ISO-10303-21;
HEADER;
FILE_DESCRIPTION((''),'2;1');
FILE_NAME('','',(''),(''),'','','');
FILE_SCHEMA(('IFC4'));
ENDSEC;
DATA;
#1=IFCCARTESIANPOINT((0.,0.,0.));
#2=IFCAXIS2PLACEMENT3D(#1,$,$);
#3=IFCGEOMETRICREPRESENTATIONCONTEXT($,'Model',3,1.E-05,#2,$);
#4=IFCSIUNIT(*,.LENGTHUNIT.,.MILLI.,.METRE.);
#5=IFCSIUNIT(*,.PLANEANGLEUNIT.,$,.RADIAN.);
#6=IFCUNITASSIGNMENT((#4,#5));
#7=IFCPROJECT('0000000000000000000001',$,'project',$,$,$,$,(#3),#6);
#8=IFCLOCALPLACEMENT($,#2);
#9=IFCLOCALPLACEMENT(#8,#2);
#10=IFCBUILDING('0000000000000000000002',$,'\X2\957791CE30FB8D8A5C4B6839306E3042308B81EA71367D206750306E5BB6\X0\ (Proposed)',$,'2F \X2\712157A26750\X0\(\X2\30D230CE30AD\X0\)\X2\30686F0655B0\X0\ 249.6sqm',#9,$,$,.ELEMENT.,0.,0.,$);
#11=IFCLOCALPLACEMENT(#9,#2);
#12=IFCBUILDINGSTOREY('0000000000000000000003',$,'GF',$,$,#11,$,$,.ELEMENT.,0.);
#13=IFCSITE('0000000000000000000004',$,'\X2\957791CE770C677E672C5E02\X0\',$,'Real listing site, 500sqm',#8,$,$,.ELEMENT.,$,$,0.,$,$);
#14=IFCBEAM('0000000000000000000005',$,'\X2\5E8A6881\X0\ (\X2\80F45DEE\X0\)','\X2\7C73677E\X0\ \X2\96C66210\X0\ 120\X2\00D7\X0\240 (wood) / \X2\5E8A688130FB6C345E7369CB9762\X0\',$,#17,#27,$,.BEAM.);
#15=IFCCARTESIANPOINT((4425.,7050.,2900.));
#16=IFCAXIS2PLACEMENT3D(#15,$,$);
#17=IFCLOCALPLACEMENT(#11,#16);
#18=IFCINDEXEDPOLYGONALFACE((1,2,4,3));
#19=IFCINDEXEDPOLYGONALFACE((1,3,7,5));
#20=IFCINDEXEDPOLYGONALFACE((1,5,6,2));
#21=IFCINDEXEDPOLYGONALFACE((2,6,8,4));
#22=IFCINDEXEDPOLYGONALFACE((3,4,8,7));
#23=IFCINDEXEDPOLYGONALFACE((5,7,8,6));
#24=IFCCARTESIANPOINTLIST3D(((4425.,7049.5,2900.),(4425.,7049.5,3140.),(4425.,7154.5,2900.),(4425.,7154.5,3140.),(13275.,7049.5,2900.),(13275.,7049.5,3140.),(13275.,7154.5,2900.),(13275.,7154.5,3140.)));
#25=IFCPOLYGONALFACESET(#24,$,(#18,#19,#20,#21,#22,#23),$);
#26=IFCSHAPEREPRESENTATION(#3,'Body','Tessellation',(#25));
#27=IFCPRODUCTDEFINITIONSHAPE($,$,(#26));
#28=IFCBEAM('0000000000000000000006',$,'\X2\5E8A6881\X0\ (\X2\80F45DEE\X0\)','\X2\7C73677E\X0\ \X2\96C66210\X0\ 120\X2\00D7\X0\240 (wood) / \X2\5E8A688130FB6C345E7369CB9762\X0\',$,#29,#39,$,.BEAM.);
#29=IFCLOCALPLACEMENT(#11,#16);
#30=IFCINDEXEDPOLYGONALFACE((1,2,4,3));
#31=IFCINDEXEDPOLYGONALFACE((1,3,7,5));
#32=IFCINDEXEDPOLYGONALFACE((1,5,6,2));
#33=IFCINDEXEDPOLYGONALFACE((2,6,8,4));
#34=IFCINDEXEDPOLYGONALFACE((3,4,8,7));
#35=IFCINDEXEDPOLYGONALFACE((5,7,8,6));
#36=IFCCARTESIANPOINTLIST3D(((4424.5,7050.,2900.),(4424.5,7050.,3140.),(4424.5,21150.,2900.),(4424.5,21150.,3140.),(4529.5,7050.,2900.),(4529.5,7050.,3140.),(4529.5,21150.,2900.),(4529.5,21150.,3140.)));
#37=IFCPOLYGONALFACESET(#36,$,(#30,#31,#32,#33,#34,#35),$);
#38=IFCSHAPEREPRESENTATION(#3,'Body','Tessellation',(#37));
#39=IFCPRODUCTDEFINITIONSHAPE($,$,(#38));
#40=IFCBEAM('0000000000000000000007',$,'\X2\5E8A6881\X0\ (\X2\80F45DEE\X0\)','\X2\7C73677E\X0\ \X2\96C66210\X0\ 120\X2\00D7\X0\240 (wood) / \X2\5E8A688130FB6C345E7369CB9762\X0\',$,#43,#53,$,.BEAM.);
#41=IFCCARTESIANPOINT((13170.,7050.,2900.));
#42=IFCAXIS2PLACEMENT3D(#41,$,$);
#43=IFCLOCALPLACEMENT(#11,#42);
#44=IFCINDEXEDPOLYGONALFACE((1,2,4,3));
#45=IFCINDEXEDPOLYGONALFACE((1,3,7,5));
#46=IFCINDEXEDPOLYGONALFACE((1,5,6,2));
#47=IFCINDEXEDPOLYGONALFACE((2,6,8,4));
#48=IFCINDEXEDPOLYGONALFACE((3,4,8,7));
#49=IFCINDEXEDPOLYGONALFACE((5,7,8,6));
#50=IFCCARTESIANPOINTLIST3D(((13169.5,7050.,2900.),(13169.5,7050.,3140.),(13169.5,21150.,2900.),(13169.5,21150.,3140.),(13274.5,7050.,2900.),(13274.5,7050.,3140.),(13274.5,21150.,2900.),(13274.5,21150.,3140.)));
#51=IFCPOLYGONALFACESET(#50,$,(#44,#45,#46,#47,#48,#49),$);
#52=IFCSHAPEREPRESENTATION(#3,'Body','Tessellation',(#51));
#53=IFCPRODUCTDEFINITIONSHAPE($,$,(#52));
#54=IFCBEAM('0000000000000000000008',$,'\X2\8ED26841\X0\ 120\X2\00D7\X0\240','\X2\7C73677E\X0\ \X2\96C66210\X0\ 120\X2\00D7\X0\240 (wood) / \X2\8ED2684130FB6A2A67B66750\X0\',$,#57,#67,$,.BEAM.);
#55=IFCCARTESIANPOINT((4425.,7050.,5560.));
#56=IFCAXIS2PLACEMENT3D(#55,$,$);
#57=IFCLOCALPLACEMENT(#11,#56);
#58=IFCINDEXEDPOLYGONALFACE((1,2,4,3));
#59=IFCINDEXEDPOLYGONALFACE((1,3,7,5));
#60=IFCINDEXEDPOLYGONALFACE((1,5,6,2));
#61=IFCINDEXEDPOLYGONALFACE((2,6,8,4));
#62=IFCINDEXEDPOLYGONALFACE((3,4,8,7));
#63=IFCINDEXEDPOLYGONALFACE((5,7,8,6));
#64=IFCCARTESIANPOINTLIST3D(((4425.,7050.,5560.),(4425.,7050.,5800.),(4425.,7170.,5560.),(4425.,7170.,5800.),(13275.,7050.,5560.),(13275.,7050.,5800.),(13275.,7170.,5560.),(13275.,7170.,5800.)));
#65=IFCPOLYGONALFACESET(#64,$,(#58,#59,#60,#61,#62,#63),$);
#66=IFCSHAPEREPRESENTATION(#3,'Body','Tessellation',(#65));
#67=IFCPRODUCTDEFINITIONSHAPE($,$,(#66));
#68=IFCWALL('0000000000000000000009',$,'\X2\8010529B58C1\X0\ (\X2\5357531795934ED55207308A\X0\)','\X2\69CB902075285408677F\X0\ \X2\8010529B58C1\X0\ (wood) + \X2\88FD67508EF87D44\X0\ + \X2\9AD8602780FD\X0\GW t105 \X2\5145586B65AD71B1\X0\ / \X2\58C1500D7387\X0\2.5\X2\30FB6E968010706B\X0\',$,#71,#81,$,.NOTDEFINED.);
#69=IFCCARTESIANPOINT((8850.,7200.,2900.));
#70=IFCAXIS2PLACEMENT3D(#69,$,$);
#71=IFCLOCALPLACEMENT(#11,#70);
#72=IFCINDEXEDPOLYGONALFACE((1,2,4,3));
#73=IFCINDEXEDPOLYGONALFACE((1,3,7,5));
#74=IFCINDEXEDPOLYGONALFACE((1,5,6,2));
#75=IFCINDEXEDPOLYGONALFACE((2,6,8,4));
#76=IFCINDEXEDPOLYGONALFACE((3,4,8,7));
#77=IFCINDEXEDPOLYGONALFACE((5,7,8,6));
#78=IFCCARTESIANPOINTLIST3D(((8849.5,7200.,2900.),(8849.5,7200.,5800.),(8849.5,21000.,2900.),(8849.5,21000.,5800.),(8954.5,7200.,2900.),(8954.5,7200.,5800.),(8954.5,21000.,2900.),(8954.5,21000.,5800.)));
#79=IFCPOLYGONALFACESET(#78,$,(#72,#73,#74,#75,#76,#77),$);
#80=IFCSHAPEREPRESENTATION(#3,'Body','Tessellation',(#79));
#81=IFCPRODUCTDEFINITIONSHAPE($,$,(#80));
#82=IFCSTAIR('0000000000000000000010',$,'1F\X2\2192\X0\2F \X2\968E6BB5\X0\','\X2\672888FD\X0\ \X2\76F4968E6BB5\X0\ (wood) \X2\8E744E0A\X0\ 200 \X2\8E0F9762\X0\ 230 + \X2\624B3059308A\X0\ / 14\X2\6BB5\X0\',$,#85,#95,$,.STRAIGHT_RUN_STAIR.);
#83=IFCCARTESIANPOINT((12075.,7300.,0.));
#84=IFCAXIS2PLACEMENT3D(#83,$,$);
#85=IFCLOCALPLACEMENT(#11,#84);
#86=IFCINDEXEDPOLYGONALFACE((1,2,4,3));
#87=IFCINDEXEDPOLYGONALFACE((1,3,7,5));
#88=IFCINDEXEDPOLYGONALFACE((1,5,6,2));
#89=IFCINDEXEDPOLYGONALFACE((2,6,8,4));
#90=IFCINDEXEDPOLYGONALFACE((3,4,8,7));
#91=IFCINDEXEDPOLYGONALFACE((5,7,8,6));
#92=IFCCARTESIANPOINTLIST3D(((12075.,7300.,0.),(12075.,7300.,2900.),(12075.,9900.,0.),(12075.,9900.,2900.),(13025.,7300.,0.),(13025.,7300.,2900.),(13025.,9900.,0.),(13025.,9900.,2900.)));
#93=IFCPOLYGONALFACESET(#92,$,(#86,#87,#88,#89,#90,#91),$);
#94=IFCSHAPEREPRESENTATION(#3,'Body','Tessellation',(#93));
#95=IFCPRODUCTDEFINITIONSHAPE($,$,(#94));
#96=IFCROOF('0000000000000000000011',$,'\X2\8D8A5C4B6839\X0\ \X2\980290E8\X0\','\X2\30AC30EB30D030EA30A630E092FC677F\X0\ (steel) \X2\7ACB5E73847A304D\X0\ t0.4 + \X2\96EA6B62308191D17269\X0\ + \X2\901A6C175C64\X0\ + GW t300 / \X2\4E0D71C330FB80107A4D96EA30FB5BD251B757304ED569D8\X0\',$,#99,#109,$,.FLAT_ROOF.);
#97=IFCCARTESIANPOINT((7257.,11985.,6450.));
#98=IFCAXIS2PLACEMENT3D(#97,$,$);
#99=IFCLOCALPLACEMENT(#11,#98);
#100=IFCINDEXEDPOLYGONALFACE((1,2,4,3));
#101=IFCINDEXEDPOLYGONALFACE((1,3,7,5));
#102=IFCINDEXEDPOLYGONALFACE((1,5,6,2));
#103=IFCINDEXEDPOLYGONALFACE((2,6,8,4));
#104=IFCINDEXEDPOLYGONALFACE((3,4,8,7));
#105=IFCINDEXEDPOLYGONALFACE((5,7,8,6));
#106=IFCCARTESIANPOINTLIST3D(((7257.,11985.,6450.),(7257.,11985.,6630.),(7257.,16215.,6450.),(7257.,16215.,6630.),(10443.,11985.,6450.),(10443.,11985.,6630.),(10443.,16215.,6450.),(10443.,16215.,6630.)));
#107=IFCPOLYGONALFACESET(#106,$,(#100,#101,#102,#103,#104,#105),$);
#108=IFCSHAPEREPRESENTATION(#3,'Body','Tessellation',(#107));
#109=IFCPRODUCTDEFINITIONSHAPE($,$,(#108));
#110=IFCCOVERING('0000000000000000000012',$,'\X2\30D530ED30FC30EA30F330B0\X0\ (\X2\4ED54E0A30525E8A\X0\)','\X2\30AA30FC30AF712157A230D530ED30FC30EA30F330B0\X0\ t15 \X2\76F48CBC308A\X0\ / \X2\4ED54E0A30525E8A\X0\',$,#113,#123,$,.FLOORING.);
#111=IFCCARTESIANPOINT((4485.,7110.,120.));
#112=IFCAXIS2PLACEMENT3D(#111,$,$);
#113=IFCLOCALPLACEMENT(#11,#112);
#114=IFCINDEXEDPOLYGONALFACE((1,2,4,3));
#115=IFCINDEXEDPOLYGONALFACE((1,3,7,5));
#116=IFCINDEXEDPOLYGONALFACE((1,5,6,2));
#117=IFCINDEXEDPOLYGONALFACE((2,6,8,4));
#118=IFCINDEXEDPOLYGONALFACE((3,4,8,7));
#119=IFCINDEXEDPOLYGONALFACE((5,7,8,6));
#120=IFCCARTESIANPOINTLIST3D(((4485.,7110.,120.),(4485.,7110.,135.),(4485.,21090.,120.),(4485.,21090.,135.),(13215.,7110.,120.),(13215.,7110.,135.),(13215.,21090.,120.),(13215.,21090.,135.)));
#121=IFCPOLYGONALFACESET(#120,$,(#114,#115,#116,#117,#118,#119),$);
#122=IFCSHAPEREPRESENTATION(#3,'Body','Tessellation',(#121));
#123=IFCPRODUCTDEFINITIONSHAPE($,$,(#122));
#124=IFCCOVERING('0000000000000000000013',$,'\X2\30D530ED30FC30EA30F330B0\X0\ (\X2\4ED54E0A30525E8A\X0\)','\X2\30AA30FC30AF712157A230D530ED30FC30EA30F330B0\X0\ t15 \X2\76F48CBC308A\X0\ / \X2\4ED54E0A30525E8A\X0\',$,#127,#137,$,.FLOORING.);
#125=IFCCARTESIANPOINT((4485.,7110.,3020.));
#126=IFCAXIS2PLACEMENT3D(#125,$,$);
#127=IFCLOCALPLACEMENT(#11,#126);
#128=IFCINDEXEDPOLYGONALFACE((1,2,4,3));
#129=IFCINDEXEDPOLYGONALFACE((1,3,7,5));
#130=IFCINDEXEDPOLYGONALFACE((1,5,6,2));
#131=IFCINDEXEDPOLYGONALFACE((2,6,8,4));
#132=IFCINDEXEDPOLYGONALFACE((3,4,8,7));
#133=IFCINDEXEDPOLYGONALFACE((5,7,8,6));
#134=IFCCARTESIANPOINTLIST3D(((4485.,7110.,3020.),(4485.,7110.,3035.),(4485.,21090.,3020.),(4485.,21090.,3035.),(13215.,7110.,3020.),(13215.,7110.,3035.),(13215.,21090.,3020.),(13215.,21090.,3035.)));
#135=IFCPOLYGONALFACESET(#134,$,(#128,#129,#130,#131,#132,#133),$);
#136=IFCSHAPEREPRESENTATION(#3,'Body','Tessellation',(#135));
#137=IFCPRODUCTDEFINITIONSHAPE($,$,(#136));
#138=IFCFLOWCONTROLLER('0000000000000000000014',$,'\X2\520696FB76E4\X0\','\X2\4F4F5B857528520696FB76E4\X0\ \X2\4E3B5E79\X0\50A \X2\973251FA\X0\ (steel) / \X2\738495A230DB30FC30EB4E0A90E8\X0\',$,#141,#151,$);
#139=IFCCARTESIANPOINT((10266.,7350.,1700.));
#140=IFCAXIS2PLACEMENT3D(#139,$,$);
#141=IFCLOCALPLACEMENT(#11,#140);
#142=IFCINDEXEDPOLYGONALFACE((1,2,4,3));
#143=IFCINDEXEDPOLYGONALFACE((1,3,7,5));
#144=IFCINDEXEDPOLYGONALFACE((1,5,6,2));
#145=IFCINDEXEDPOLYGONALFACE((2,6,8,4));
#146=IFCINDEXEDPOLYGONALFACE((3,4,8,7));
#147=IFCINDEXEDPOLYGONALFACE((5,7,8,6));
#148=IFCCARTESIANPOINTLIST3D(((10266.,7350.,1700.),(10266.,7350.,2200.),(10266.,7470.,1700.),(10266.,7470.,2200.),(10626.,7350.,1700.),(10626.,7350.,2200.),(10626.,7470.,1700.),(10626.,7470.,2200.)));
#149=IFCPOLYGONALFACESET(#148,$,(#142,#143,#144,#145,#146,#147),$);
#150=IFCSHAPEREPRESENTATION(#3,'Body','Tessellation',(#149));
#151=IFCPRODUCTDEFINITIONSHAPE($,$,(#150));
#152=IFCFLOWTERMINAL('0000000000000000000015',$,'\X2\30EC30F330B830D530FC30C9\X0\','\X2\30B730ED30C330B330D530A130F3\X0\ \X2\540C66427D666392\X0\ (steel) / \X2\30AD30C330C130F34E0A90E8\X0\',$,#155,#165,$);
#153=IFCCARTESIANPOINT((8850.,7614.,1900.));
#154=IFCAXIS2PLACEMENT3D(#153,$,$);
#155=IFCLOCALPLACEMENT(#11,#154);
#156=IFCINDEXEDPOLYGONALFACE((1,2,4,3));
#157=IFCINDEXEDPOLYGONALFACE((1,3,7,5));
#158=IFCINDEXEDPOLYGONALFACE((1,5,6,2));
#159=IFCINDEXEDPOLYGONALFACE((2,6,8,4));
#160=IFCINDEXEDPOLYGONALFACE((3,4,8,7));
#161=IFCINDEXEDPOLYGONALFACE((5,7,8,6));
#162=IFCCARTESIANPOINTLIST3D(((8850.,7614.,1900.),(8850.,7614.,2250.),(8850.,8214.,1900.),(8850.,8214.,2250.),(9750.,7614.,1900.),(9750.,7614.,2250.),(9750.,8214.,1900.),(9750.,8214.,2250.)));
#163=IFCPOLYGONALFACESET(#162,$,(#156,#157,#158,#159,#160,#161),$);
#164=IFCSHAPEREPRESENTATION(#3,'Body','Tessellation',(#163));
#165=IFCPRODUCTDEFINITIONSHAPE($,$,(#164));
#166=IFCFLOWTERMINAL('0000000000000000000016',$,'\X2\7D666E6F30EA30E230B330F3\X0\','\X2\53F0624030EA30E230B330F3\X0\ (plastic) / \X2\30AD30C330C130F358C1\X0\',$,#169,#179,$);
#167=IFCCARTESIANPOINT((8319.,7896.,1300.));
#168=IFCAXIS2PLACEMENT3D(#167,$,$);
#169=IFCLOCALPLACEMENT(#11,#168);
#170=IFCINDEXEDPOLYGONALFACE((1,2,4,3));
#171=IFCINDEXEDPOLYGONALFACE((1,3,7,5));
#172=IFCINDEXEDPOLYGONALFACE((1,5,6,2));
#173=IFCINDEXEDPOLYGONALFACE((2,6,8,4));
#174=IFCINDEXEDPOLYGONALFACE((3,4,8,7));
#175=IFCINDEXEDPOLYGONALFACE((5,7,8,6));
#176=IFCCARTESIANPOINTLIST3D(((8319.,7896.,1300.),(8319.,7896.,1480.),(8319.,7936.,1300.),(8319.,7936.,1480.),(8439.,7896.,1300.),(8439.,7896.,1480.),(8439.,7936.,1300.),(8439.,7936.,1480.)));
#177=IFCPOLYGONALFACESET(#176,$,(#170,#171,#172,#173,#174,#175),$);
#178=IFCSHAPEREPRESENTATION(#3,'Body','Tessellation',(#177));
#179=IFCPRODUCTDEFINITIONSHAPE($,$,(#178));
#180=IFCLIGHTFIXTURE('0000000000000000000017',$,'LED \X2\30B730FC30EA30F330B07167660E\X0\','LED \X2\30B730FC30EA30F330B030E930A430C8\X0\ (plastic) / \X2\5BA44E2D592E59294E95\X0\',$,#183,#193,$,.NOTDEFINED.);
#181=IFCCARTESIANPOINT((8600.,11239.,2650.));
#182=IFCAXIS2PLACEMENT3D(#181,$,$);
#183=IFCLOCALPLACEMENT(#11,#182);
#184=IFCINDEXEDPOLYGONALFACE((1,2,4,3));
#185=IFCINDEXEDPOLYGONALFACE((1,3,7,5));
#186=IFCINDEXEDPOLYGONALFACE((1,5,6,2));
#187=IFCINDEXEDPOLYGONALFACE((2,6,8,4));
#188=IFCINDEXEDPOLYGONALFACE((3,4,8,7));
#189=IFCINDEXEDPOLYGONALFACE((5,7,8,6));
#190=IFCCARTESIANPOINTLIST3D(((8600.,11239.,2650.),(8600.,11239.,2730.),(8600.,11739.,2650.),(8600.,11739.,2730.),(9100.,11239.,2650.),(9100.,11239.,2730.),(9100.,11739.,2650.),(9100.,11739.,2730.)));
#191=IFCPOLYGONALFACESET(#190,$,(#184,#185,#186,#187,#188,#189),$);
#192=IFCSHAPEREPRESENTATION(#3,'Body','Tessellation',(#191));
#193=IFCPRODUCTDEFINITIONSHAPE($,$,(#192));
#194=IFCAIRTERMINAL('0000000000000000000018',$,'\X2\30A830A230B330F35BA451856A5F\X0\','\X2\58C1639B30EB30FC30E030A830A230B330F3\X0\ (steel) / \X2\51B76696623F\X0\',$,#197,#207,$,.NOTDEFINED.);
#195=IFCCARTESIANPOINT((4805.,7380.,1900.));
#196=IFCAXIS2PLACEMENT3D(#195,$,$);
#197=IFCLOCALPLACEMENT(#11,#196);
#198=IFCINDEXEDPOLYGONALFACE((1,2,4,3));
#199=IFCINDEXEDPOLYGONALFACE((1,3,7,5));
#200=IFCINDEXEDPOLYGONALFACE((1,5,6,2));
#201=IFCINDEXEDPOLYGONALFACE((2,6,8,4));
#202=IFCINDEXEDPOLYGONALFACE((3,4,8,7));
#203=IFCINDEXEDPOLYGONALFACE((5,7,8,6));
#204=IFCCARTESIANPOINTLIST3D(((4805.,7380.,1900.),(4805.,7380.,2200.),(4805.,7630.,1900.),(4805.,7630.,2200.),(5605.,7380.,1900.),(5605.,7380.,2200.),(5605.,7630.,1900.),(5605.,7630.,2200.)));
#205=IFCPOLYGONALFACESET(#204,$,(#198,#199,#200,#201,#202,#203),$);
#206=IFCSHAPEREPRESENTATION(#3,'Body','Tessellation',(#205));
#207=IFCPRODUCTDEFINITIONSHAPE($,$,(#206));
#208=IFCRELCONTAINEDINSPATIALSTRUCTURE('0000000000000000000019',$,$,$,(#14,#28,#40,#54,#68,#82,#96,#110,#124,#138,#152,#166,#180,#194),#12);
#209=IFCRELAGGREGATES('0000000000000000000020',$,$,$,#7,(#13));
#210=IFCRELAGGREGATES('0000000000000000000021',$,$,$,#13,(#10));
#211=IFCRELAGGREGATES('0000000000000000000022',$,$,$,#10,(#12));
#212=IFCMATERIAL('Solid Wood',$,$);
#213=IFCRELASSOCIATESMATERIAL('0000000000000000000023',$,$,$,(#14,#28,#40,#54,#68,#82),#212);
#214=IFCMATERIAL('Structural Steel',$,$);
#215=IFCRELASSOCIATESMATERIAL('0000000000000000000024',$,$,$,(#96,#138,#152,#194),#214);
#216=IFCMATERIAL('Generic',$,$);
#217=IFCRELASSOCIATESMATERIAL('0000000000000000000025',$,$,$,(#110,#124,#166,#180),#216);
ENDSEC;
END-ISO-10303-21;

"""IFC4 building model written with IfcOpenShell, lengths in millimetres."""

from ifc_helpers import new_model, si_unit, frame, frame_2d, origin, place, context, project, spatial, rectangle, extrude, material, element, save


model = new_model("IFC4")

# Units and contexts
model_context = context("Model", 3, precision=1e-05, world=origin())
ifc_project = project(units=[si_unit("LENGTHUNIT", "METRE", prefix="MILLI"), si_unit("PLANEANGLEUNIT", "RADIAN")], contexts=[model_context])

# Site, building, storey
site_placement = place(None, origin())
site = spatial("IfcSite", under=ifc_project, at=site_placement, Name="長野県松本市", ObjectType="Real listing site, 500sqm", CompositionType="ELEMENT", RefElevation=0.0)
building_placement = place(site_placement, origin())
building = spatial("IfcBuilding", under=site, at=building_placement, Name="長野・越屋根のある自然素材の家 (Proposed)", ObjectType="2F 無垢材(ヒノキ)と漆喰 249.6sqm", CompositionType="ELEMENT", ElevationOfRefHeight=0.0, ElevationOfTerrain=0.0)
storey_placement = place(building_placement, origin())
storey = spatial("IfcBuildingStorey", under=building, at=storey_placement, Name="GF", CompositionType="ELEMENT", Elevation=0.0)

# Shared definitions
ifc_material_1 = material(Name="Solid Wood")

# Beams
beam_1_placement = place(storey_placement, frame((4425.0, 7050.0, 2900.0)))
element("IfcBeam", 1, at=beam_1_placement, inside=storey, material=ifc_material_1, Name="床梁 (胴差)", Description="米松 集成 120×240 (wood) / 床梁・水平構面", PredefinedType="BEAM", context=model_context, shape_type="SweptSolid", body=[
    extrude(rectangle(XDim=8850.0, YDim=105.0, at=frame_2d((4425.0, 52.0))), frame((4425.0, 7050.0, 2900.0)), (0.0, 0.0, 1.0), 240.0),
])
beam_2_placement = place(storey_placement, frame((4425.0, 7050.0, 2900.0)))
element("IfcBeam", 2, at=beam_2_placement, inside=storey, material=ifc_material_1, Name="床梁 (胴差)", Description="米松 集成 120×240 (wood) / 床梁・水平構面", PredefinedType="BEAM", context=model_context, shape_type="SweptSolid", body=[
    extrude(rectangle(XDim=105.0, YDim=14100.0, at=frame_2d((52.0, 7050.0))), frame((4425.0, 7050.0, 2900.0)), (0.0, 0.0, 1.0), 240.0),
])
beam_3_placement = place(storey_placement, frame((13170.0, 7050.0, 2900.0)))
element("IfcBeam", 3, at=beam_3_placement, inside=storey, material=ifc_material_1, Name="床梁 (胴差)", Description="米松 集成 120×240 (wood) / 床梁・水平構面", PredefinedType="BEAM", context=model_context, shape_type="SweptSolid", body=[
    extrude(rectangle(XDim=105.0, YDim=14100.0, at=frame_2d((52.0, 7050.0))), frame((13170.0, 7050.0, 2900.0)), (0.0, 0.0, 1.0), 240.0),
])
beam_4_placement = place(storey_placement, frame((4425.0, 7050.0, 5560.0)))
element("IfcBeam", 4, at=beam_4_placement, inside=storey, material=ifc_material_1, Name="軒桁 120×240", Description="米松 集成 120×240 (wood) / 軒桁・横架材", PredefinedType="BEAM", context=model_context, shape_type="SweptSolid", body=[
    extrude(rectangle(XDim=8850.0, YDim=120.0, at=frame_2d((4425.0, 60.0))), frame((4425.0, 7050.0, 5560.0)), (0.0, 0.0, 1.0), 240.0),
])

# Wall
wall_1_placement = place(storey_placement, frame((8850.0, 7200.0, 2900.0)))
element("IfcWall", 5, at=wall_1_placement, inside=storey, material=ifc_material_1, Name="耐力壁 (南北間仕切り)", Description="構造用合板 耐力壁 (wood) + 製材軸組 + 高性能GW t105 充填断熱 / 壁倍率2.5・準耐火", PredefinedType="NOTDEFINED", context=model_context, shape_type="SweptSolid", body=[
    extrude(rectangle(XDim=105.0, YDim=13800.0, at=frame_2d((52.0, 6900.0))), frame((8850.0, 7200.0, 2900.0)), (0.0, 0.0, 1.0), 2900.0),
])

# Stair
stair_placement = place(storey_placement, frame((12075.0, 7300.0, 0.0)))
element("IfcStair", 6, at=stair_placement, inside=storey, material=ifc_material_1, Name="1F→2F 階段", Description="木製 直階段 (wood) 蹴上 200 踏面 230 + 手すり / 14段", PredefinedType="STRAIGHT_RUN_STAIR", context=model_context, shape_type="SweptSolid", body=[
    extrude(rectangle(XDim=950.0, YDim=2600.0, at=frame_2d((475.0, 1300.0))), frame((12075.0, 7300.0, 0.0)), (0.0, 0.0, 1.0), 2900.0),
])

# Roof
ifc_material_2 = material(Name="Structural Steel")
roof_placement = place(storey_placement, frame((7257.0, 11985.0, 6450.0)))
element("IfcRoof", 7, at=roof_placement, inside=storey, material=ifc_material_2, Name="越屋根 頂部", Description="ガルバリウム鋼板 (steel) 立平葺き t0.4 + 雪止め金物 + 通気層 + GW t300 / 不燃・耐積雪・寒冷地仕様", PredefinedType="FLAT_ROOF", context=model_context, shape_type="SweptSolid", body=[
    extrude(rectangle(XDim=3186.0, YDim=4230.0, at=frame_2d((1593.0, 2115.0))), frame((7257.0, 11985.0, 6450.0)), (0.0, 0.0, 1.0), 180.0),
])

# Coverings
ifc_material_3 = material(Name="Generic")
covering_1_placement = place(storey_placement, frame((4485.0, 7110.0, 120.0)))
element("IfcCovering", 8, at=covering_1_placement, inside=storey, material=ifc_material_3, Name="フローリング (仕上げ床)", Description="オーク無垢フローリング t15 直貼り / 仕上げ床", PredefinedType="FLOORING", context=model_context, shape_type="SweptSolid", body=[
    extrude(rectangle(XDim=8730.0, YDim=13980.0, at=frame_2d((4365.0, 6990.0))), frame((4485.0, 7110.0, 120.0)), (0.0, 0.0, 1.0), 15.0),
])
covering_2_placement = place(storey_placement, frame((4485.0, 7110.0, 3020.0)))
element("IfcCovering", 9, at=covering_2_placement, inside=storey, material=ifc_material_3, Name="フローリング (仕上げ床)", Description="オーク無垢フローリング t15 直貼り / 仕上げ床", PredefinedType="FLOORING", context=model_context, shape_type="SweptSolid", body=[
    extrude(rectangle(XDim=8730.0, YDim=13980.0, at=frame_2d((4365.0, 6990.0))), frame((4485.0, 7110.0, 3020.0)), (0.0, 0.0, 1.0), 15.0),
])

# Flow controller
flow_controller_placement = place(storey_placement, frame((10266.0, 7350.0, 1700.0)))
element("IfcFlowController", 10, at=flow_controller_placement, inside=storey, material=ifc_material_2, Name="分電盤", Description="住宅用分電盤 主幹50A 露出 (steel) / 玄関ホール上部", context=model_context, shape_type="SweptSolid", body=[
    extrude(rectangle(XDim=360.0, YDim=120.0, at=frame_2d((180.0, 60.0))), frame((10266.0, 7350.0, 1700.0)), (0.0, 0.0, 1.0), 500.0),
])

# Flow terminals
flow_terminal_1_placement = place(storey_placement, frame((8850.0, 7614.0, 1900.0)))
element("IfcFlowTerminal", 11, at=flow_terminal_1_placement, inside=storey, material=ifc_material_2, Name="レンジフード", Description="シロッコファン 同時給排 (steel) / キッチン上部", context=model_context, shape_type="SweptSolid", body=[
    extrude(rectangle(XDim=900.0, YDim=600.0, at=frame_2d((450.0, 300.0))), frame((8850.0, 7614.0, 1900.0)), (0.0, 0.0, 1.0), 350.0),
])
flow_terminal_2_placement = place(storey_placement, frame((8319.0, 7896.0, 1300.0)))
element("IfcFlowTerminal", 12, at=flow_terminal_2_placement, inside=storey, material=ifc_material_3, Name="給湯リモコン", Description="台所リモコン (plastic) / キッチン壁", context=model_context, shape_type="SweptSolid", body=[
    extrude(rectangle(XDim=120.0, YDim=40.0, at=frame_2d((60.0, 20.0))), frame((8319.0, 7896.0, 1300.0)), (0.0, 0.0, 1.0), 180.0),
])

# Light fixture
light_fixture_1_placement = place(storey_placement, frame((8600.0, 11239.0, 2650.0)))
element("IfcLightFixture", 13, at=light_fixture_1_placement, inside=storey, material=ifc_material_3, Name="LED シーリング照明", Description="LED シーリングライト (plastic) / 室中央天井", PredefinedType="NOTDEFINED", context=model_context, shape_type="SweptSolid", body=[
    extrude(rectangle(XDim=500.0, YDim=500.0, at=frame_2d((250.0, 250.0))), frame((8600.0, 11239.0, 2650.0)), (0.0, 0.0, 1.0), 80.0),
])

# Air terminal
air_terminal_1_placement = place(storey_placement, frame((4805.0, 7380.0, 1900.0)))
element("IfcAirTerminal", 14, at=air_terminal_1_placement, inside=storey, material=ifc_material_2, Name="エアコン室内機", Description="壁掛ルームエアコン (steel) / 冷暖房", PredefinedType="NOTDEFINED", context=model_context, shape_type="SweptSolid", body=[
    extrude(rectangle(XDim=800.0, YDim=250.0, at=frame_2d((400.0, 125.0))), frame((4805.0, 7380.0, 1900.0)), (0.0, 0.0, 1.0), 300.0),
])

save(model, "model.ifc")
